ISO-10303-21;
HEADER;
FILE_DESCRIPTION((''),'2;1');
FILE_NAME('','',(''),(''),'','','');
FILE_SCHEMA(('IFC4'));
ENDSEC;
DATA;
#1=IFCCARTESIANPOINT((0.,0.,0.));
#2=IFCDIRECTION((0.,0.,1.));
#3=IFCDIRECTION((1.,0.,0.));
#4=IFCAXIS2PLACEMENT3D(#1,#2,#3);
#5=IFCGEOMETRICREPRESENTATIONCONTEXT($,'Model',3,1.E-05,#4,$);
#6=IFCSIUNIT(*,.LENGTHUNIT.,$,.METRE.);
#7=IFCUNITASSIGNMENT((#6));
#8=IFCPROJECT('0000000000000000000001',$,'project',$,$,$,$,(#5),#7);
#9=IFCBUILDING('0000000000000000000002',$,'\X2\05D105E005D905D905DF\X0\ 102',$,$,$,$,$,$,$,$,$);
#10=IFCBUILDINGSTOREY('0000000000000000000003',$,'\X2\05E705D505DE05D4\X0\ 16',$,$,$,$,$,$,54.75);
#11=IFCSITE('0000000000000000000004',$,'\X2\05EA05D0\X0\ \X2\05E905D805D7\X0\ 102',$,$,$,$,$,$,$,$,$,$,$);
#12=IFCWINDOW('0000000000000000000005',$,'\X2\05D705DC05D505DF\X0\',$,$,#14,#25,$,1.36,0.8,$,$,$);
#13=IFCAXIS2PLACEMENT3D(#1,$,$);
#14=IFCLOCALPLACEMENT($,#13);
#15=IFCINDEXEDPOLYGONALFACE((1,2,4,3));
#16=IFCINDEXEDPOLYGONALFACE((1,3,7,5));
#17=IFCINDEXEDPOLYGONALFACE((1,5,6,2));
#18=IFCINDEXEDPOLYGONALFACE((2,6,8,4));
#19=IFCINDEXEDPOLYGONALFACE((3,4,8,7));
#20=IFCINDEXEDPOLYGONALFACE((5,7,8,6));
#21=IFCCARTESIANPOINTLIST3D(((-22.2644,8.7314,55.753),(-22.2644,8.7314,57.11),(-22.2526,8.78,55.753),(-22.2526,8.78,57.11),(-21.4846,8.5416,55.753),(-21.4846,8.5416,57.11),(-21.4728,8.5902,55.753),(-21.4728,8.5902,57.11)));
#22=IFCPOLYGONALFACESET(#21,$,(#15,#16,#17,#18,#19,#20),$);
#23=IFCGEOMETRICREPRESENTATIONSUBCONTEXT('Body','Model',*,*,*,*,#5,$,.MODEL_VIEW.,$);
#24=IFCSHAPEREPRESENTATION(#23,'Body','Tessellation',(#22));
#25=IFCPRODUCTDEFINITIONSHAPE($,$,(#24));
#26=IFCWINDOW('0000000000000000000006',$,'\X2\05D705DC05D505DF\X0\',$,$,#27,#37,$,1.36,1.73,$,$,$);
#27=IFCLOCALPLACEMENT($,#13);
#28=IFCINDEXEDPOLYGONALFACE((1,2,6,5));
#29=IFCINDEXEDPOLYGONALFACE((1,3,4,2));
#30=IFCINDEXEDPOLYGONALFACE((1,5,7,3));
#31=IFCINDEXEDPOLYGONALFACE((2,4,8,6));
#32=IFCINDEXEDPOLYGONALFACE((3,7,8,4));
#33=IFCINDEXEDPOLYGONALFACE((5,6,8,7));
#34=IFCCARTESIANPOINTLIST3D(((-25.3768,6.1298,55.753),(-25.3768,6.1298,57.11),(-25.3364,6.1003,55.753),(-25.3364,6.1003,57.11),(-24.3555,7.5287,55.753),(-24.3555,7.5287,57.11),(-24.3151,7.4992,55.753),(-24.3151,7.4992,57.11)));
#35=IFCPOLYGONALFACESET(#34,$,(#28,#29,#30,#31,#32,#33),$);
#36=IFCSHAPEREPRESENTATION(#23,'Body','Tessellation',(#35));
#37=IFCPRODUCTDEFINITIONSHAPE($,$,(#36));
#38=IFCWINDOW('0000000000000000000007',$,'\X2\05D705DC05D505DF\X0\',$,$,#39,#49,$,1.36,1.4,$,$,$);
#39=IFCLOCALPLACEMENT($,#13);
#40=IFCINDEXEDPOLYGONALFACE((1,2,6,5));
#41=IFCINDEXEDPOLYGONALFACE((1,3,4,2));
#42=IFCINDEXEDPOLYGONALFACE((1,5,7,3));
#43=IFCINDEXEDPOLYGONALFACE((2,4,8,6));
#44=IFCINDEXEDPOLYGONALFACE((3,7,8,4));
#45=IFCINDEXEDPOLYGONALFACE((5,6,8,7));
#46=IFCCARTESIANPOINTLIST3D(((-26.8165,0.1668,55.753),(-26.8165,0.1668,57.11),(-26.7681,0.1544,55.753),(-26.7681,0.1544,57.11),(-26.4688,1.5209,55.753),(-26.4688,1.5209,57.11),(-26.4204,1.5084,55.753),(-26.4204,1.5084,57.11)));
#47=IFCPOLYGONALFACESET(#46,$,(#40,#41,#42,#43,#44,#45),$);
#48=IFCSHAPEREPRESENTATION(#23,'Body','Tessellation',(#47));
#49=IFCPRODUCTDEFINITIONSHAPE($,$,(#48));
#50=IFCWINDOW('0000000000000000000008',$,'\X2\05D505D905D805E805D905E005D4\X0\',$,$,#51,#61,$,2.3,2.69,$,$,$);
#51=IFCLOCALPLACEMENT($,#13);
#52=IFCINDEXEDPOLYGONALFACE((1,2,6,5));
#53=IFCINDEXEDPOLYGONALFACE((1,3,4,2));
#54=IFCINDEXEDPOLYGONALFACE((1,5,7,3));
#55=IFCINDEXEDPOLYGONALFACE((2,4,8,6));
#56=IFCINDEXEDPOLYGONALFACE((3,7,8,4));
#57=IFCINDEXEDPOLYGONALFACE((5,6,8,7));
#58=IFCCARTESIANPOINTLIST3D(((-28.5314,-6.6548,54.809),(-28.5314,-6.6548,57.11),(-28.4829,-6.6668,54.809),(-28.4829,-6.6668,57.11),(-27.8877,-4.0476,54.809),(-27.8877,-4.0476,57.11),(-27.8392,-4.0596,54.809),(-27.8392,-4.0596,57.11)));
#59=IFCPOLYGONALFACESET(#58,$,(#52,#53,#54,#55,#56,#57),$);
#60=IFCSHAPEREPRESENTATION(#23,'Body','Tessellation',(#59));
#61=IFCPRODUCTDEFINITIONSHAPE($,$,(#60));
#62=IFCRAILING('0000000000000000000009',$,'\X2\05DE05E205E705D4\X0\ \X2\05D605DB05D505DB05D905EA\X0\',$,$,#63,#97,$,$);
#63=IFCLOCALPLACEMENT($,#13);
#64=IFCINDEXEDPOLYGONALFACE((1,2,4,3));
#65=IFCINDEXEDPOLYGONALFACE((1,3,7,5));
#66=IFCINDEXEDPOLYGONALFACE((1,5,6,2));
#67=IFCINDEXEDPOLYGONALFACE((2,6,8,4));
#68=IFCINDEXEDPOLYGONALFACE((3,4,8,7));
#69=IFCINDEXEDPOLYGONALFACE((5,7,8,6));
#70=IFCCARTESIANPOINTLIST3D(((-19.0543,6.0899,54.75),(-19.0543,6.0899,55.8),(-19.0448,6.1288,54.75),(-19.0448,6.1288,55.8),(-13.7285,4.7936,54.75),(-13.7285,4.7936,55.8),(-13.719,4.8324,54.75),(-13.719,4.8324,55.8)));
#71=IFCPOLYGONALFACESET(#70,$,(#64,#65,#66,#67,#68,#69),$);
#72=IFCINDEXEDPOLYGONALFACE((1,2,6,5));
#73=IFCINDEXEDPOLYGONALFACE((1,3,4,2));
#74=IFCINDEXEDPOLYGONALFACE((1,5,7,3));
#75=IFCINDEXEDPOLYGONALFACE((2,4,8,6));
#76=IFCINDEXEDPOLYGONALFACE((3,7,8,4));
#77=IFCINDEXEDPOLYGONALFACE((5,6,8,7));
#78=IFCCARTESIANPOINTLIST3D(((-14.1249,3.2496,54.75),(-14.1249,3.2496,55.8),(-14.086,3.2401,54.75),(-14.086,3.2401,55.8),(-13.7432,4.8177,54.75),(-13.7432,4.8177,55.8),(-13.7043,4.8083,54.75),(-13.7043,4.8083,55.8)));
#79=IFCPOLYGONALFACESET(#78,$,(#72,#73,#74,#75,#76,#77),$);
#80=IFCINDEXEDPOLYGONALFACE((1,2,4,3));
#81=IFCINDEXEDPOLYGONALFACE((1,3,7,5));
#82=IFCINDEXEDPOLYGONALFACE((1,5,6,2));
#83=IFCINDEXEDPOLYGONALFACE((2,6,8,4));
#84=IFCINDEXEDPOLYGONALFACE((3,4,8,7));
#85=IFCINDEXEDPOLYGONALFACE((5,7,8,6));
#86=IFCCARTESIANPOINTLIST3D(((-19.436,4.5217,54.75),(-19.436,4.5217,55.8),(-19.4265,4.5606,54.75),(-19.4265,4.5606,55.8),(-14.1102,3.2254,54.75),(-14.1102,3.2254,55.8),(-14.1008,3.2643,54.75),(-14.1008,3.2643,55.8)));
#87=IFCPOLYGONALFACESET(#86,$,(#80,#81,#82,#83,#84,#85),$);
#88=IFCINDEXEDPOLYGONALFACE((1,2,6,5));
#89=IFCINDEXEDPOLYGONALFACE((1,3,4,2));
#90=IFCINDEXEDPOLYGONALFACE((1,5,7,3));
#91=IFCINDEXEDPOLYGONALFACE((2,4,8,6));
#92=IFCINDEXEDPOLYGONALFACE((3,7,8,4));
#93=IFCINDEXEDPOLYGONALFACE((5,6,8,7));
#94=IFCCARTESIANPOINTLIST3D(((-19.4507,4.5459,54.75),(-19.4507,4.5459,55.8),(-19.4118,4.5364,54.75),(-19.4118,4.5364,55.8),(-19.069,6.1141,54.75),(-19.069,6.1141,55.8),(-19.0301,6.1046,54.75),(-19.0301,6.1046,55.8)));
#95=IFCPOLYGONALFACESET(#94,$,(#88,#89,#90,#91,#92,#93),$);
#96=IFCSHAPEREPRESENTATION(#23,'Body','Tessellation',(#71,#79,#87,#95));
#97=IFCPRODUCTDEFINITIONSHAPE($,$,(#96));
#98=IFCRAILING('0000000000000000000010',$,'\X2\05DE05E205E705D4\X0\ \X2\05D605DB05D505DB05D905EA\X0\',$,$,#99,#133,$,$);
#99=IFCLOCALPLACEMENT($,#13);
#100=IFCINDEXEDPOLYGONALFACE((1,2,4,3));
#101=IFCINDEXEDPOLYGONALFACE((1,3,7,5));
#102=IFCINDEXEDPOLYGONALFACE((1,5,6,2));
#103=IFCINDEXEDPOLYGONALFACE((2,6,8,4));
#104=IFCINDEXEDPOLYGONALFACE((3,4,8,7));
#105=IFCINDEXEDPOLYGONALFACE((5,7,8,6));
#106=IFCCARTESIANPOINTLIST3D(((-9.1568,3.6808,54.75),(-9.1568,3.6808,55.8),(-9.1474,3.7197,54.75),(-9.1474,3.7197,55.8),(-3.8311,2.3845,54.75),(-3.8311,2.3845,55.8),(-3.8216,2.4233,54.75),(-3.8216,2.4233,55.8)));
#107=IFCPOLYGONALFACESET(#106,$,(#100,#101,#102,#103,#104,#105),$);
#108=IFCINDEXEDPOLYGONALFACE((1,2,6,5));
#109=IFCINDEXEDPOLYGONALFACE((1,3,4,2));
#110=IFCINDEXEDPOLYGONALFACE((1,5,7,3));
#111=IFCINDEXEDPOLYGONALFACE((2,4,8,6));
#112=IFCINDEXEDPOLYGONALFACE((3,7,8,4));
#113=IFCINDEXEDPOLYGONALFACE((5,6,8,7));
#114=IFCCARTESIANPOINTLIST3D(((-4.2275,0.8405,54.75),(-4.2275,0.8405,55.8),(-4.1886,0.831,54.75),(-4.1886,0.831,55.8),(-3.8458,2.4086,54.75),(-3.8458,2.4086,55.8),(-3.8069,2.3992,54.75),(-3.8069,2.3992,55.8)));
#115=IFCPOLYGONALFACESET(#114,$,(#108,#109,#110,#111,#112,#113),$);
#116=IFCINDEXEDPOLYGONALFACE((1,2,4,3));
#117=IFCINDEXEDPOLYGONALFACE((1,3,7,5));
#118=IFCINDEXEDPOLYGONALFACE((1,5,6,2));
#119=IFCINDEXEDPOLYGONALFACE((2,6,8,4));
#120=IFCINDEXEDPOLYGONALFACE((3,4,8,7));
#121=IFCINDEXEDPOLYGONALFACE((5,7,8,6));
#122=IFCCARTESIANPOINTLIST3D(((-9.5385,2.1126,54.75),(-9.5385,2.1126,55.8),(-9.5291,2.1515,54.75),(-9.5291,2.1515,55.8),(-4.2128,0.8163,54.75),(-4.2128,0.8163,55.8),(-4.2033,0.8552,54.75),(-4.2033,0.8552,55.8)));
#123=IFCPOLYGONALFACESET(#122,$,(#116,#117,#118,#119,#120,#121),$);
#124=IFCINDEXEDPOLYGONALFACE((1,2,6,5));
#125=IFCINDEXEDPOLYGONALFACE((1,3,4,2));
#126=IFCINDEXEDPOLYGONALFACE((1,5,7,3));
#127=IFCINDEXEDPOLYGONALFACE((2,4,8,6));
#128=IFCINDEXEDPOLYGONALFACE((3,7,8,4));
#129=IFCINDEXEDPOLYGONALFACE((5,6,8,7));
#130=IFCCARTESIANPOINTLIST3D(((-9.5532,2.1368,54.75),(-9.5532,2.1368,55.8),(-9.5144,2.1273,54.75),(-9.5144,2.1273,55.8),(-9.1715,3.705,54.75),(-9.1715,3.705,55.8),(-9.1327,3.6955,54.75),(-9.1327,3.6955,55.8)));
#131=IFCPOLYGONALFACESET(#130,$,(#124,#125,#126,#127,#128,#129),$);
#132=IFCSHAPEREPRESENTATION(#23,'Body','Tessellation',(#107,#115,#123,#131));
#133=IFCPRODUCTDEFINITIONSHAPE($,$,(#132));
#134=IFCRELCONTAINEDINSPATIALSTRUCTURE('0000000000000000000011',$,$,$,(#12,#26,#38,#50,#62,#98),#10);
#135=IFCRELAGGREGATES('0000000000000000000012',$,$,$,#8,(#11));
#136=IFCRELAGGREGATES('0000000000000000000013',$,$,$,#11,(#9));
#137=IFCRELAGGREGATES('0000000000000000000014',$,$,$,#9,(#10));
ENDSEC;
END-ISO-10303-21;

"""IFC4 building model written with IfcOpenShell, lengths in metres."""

from ifc_helpers import new_model, si_unit, frame, origin_with_axes, context, subcontext, project, spatial, polyline, outline, extrude, element, save


model = new_model("IFC4")

# Units and contexts
model_context = context("Model", 3, precision=1e-05, world=origin_with_axes())
body_context = subcontext(model_context, "Body", "Model", "MODEL_VIEW")
ifc_project = project(units=[si_unit("LENGTHUNIT", "METRE")], contexts=[model_context])

# Site, building, storey
site = spatial("IfcSite", under=ifc_project, Name="תא שטח 102")
building = spatial("IfcBuilding", under=site, Name="בניין 102")
storey = spatial("IfcBuildingStorey", under=building, Name="קומה 16", Elevation=54.75)

# Windows
element("IfcWindow", 1, inside=storey, Name="חלון", OverallHeight=1.36, OverallWidth=0.8, context=body_context, shape_type="SweptSolid", body=[
    extrude(outline(polyline([(-21.4728, 8.5902), (-22.2526, 8.78), (-22.2644, 8.7314), (-21.4846, 8.5416), (-21.4728, 8.5902)])), frame((0.0, 0.0, 55.753)), (0.0, 0.0, 1.0), 1.357),
])
element("IfcWindow", 2, inside=storey, Name="חלון", OverallHeight=1.36, OverallWidth=1.73, context=body_context, shape_type="SweptSolid", body=[
    extrude(outline(polyline([(-24.3555, 7.5287), (-25.3768, 6.1298), (-25.3364, 6.1003), (-24.3151, 7.4992), (-24.3555, 7.5287)])), frame((0.0, 0.0, 55.753)), (0.0, 0.0, 1.0), 1.357),
])
element("IfcWindow", 3, inside=storey, Name="חלון", OverallHeight=1.36, OverallWidth=1.4, context=body_context, shape_type="SweptSolid", body=[
    extrude(outline(polyline([(-26.4688, 1.5209), (-26.8165, 0.1668), (-26.7681, 0.1544), (-26.4204, 1.5084), (-26.4688, 1.5209)])), frame((0.0, 0.0, 55.753)), (0.0, 0.0, 1.0), 1.357),
])
element("IfcWindow", 4, inside=storey, Name="ויטרינה", OverallHeight=2.3, OverallWidth=2.69, context=body_context, shape_type="SweptSolid", body=[
    extrude(outline(polyline([(-27.8877, -4.0476), (-28.5314, -6.6548), (-28.4829, -6.6668), (-27.8392, -4.0596), (-27.8877, -4.0476)])), frame((0.0, 0.0, 54.809)), (0.0, 0.0, 1.0), 2.301),
])

# Railings
element("IfcRailing", 5, inside=storey, Name="מעקה זכוכית", context=body_context, shape_type="SweptSolid", body=[
    extrude(outline(polyline([(-19.0543, 6.0899), (-13.7285, 4.7936), (-13.719, 4.8324), (-19.0448, 6.1288), (-19.0543, 6.0899)])), frame((0.0, 0.0, 54.75)), (0.0, 0.0, 1.0), 1.05),
    extrude(outline(polyline([(-13.7432, 4.8177), (-14.1249, 3.2496), (-14.086, 3.2401), (-13.7043, 4.8083), (-13.7432, 4.8177)])), frame((0.0, 0.0, 54.75)), (0.0, 0.0, 1.0), 1.05),
    extrude(outline(polyline([(-14.1008, 3.2643), (-19.4265, 4.5606), (-19.436, 4.5217), (-14.1102, 3.2254), (-14.1008, 3.2643)])), frame((0.0, 0.0, 54.75)), (0.0, 0.0, 1.0), 1.05),
    extrude(outline(polyline([(-19.4118, 4.5364), (-19.0301, 6.1046), (-19.069, 6.1141), (-19.4507, 4.5459), (-19.4118, 4.5364)])), frame((0.0, 0.0, 54.75)), (0.0, 0.0, 1.0), 1.05),
])
element("IfcRailing", 6, inside=storey, Name="מעקה זכוכית", context=body_context, shape_type="SweptSolid", body=[
    extrude(outline(polyline([(-9.1568, 3.6808), (-3.8311, 2.3845), (-3.8216, 2.4233), (-9.1474, 3.7197), (-9.1568, 3.6808)])), frame((0.0, 0.0, 54.75)), (0.0, 0.0, 1.0), 1.05),
    extrude(outline(polyline([(-3.8458, 2.4086), (-4.2275, 0.8405), (-4.1886, 0.831), (-3.8069, 2.3992), (-3.8458, 2.4086)])), frame((0.0, 0.0, 54.75)), (0.0, 0.0, 1.0), 1.05),
    extrude(outline(polyline([(-4.2033, 0.8552), (-9.5291, 2.1515), (-9.5385, 2.1126), (-4.2128, 0.8163), (-4.2033, 0.8552)])), frame((0.0, 0.0, 54.75)), (0.0, 0.0, 1.0), 1.05),
    extrude(outline(polyline([(-9.5144, 2.1273), (-9.1327, 3.6955), (-9.1715, 3.705), (-9.5532, 2.1368), (-9.5144, 2.1273)])), frame((0.0, 0.0, 54.75)), (0.0, 0.0, 1.0), 1.05),
])

save(model, "model.ifc")
